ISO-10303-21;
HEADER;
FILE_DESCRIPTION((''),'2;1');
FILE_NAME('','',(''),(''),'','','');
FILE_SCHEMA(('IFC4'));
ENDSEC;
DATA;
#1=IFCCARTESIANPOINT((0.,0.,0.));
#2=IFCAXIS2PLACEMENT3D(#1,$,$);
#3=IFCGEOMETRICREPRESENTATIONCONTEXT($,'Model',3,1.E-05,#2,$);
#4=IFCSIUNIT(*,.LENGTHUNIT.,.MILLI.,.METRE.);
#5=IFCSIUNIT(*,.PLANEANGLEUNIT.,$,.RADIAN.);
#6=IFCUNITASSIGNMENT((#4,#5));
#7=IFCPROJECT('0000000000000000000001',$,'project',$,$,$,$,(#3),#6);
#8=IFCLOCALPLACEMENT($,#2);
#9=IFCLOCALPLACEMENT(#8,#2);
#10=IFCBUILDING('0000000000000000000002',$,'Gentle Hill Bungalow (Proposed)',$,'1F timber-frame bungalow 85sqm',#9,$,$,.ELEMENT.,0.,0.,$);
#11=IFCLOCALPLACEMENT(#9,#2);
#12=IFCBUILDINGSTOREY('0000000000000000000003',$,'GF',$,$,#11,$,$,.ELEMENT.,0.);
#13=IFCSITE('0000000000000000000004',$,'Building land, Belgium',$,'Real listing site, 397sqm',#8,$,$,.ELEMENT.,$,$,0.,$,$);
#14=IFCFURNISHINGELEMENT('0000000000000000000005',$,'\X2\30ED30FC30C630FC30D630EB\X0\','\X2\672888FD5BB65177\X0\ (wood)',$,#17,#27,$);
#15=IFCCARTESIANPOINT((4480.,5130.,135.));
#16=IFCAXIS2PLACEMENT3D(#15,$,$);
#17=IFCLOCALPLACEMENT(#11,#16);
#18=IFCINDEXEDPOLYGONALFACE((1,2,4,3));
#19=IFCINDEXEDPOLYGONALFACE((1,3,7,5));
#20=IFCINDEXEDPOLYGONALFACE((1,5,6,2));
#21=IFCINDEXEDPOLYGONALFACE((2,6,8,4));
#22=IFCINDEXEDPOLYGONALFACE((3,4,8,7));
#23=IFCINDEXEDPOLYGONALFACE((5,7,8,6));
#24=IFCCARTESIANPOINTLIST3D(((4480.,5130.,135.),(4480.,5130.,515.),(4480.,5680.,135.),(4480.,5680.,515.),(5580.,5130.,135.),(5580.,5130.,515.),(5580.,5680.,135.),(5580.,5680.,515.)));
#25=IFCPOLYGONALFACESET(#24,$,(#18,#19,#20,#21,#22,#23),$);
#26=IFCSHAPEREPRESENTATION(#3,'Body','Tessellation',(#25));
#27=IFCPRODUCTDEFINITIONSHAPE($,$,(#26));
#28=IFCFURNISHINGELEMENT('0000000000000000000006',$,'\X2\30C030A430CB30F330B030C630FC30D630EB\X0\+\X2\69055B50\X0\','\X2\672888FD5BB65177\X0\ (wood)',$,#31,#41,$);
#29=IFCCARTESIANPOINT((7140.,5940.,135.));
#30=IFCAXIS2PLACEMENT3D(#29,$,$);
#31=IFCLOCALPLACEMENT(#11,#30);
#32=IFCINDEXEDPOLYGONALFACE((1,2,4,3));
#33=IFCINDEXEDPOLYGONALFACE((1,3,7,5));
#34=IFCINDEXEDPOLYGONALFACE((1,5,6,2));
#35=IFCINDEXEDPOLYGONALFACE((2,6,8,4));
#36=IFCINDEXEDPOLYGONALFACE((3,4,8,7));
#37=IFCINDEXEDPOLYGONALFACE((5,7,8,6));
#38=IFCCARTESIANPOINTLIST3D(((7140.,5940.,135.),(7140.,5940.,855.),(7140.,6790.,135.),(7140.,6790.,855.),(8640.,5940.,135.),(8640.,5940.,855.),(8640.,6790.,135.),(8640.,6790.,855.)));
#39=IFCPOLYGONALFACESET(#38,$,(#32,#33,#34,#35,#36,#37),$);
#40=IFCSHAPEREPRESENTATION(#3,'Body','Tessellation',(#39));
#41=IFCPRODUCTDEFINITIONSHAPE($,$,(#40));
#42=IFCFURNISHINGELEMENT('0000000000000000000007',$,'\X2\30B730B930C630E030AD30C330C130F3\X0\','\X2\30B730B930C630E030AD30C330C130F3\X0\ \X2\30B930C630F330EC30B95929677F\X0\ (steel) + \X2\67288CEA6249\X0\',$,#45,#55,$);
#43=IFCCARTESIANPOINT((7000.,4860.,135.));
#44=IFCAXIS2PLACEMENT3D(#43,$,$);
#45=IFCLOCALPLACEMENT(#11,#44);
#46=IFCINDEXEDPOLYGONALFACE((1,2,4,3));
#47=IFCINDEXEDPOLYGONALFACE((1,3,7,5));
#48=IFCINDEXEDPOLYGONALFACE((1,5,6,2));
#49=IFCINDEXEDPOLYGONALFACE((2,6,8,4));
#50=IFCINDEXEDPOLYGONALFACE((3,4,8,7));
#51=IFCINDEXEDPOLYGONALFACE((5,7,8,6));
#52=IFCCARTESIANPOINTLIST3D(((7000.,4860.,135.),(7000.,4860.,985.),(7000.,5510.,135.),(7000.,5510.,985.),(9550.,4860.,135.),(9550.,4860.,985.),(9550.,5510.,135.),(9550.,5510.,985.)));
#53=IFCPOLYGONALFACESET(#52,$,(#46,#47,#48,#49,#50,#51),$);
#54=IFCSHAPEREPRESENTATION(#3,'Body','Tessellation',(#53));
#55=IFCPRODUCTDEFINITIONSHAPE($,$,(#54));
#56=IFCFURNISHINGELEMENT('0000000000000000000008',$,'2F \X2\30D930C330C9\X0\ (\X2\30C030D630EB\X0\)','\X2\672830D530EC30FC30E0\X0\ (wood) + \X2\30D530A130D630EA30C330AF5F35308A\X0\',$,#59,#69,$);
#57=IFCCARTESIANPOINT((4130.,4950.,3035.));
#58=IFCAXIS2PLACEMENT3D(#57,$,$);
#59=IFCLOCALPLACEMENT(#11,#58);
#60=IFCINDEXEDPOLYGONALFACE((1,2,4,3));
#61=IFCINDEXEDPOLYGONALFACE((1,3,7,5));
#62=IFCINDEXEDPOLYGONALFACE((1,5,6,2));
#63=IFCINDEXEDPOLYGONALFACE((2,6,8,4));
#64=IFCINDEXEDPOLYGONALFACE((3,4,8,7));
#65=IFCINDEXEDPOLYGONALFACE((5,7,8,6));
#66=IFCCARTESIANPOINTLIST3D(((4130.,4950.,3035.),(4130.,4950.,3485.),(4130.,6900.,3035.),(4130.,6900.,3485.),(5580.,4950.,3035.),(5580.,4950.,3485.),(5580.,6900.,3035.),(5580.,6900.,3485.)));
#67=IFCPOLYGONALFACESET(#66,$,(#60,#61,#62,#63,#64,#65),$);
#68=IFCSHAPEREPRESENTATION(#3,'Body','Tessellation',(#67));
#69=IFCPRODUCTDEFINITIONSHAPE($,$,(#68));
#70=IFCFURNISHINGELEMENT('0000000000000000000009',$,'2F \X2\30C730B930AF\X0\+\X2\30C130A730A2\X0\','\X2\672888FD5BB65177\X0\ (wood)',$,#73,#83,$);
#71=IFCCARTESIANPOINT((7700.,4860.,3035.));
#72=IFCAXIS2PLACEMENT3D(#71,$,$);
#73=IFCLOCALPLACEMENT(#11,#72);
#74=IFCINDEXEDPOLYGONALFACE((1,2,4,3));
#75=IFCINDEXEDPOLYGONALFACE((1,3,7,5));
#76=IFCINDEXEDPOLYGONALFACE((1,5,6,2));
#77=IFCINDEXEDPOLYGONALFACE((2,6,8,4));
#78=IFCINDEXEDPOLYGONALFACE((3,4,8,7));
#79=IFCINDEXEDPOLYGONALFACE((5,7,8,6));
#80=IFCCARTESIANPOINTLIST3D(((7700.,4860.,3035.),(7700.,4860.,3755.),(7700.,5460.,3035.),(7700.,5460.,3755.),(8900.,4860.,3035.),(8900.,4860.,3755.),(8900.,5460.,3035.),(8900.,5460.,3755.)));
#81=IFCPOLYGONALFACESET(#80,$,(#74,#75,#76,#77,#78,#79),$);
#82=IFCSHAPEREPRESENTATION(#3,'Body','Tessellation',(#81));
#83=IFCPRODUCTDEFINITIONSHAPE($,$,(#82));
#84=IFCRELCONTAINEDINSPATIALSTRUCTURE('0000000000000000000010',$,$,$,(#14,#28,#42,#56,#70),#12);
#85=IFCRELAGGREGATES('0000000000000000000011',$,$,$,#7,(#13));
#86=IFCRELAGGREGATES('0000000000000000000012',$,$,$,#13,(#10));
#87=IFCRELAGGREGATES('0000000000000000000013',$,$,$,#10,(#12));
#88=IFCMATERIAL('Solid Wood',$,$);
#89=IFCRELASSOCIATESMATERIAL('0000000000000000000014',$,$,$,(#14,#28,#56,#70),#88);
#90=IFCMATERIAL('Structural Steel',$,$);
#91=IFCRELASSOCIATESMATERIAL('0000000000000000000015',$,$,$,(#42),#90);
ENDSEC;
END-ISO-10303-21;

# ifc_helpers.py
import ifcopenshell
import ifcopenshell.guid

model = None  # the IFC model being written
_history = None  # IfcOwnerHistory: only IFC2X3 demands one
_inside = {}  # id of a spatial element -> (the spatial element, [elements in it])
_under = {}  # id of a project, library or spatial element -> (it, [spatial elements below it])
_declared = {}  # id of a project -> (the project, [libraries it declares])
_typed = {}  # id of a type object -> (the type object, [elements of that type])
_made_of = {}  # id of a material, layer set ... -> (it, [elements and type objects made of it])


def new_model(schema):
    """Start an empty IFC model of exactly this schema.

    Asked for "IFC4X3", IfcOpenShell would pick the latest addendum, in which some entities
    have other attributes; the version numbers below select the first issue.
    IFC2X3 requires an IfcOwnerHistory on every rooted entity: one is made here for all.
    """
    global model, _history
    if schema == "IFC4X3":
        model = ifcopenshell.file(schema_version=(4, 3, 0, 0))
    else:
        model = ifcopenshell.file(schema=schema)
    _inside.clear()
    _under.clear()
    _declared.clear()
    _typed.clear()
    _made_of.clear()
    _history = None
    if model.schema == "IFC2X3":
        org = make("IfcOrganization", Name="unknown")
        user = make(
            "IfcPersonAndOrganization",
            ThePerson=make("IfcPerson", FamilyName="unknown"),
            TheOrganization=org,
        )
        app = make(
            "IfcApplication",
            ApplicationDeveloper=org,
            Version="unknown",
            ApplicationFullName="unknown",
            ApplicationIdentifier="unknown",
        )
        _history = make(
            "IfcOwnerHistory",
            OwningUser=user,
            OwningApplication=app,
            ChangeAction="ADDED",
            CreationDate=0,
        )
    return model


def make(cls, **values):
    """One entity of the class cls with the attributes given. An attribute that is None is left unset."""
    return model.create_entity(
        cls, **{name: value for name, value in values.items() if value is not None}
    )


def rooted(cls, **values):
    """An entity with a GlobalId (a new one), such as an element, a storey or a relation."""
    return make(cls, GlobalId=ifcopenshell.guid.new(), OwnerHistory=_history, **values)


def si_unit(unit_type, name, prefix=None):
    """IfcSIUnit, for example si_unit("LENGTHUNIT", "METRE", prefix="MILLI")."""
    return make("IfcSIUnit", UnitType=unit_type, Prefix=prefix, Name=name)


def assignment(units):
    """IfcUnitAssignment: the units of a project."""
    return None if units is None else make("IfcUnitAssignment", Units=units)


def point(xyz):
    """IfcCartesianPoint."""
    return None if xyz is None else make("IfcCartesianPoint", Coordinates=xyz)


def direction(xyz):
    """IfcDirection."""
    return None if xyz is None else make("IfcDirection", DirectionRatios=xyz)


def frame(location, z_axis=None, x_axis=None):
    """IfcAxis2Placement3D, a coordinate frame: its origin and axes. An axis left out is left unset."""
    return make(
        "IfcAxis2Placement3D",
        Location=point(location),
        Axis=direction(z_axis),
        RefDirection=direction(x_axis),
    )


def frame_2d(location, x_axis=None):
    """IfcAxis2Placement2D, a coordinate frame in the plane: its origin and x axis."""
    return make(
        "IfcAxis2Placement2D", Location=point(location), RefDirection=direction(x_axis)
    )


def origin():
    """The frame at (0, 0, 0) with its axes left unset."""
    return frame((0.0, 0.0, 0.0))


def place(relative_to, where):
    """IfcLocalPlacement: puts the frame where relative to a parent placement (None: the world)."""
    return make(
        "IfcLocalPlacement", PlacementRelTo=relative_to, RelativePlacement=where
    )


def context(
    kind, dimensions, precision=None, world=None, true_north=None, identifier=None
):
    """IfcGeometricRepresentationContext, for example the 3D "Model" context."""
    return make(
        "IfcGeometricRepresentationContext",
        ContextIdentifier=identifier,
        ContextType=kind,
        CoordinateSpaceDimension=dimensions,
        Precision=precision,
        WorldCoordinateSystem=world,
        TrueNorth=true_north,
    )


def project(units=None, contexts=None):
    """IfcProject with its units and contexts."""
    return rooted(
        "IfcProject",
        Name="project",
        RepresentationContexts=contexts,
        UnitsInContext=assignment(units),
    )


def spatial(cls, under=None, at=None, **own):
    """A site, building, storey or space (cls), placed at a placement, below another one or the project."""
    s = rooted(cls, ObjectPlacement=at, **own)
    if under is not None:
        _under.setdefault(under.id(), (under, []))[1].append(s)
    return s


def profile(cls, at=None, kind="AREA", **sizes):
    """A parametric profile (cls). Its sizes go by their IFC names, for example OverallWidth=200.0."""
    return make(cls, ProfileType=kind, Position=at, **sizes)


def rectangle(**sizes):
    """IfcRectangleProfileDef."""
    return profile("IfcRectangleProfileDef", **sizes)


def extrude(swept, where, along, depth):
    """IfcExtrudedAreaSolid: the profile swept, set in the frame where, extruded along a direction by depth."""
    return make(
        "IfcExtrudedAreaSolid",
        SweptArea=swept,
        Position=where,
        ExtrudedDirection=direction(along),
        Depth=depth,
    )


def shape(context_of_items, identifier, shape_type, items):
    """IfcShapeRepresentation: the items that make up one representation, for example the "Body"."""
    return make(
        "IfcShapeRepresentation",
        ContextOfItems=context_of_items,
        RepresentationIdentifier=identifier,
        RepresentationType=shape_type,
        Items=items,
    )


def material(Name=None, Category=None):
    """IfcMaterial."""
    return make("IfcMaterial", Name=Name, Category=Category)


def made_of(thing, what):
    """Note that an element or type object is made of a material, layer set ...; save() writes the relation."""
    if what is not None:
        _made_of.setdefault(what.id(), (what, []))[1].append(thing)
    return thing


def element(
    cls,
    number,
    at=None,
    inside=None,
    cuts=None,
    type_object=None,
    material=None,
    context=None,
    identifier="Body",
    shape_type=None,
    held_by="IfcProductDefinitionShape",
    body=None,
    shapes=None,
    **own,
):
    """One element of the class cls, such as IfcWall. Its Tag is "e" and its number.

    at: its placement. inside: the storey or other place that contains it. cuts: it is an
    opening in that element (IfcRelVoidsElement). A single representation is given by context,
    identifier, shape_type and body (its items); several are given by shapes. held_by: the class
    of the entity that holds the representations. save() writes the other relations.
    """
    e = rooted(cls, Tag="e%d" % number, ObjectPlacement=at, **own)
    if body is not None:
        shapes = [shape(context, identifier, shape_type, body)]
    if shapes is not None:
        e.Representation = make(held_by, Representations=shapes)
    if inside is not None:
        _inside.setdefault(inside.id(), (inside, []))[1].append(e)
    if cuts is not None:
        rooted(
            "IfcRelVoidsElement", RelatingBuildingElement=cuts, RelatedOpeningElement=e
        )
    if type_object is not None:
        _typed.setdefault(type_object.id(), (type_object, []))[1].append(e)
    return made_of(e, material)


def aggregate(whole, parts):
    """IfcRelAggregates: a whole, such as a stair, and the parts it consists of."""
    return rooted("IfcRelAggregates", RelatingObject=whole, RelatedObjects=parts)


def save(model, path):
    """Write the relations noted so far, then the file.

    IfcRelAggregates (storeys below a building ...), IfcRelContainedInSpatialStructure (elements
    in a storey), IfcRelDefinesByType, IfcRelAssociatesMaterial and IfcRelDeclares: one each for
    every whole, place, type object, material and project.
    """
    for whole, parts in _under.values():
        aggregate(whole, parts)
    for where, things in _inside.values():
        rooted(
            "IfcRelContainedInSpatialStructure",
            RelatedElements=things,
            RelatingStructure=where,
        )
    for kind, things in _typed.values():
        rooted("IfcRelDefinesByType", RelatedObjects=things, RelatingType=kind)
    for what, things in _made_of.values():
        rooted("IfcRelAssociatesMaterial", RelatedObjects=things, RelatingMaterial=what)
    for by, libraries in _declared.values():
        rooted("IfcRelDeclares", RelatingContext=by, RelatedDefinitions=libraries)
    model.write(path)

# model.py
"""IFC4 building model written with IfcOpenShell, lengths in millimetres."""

from ifc_helpers import new_model, si_unit, frame, frame_2d, origin, place, context, project, spatial, rectangle, extrude, material, element, save


model = new_model("IFC4")

# Units and contexts
model_context = context("Model", 3, precision=1e-05, world=origin())
ifc_project = project(units=[si_unit("LENGTHUNIT", "METRE", prefix="MILLI"), si_unit("PLANEANGLEUNIT", "RADIAN")], contexts=[model_context])

# Site, building, storey
site_placement = place(None, origin())
site = spatial("IfcSite", under=ifc_project, at=site_placement, Name="Building land, Belgium", ObjectType="Real listing site, 397sqm", CompositionType="ELEMENT", RefElevation=0.0)
building_placement = place(site_placement, origin())
building = spatial("IfcBuilding", under=site, at=building_placement, Name="Gentle Hill Bungalow (Proposed)", ObjectType="1F timber-frame bungalow 85sqm", CompositionType="ELEMENT", ElevationOfRefHeight=0.0, ElevationOfTerrain=0.0)
storey_placement = place(building_placement, origin())
storey = spatial("IfcBuildingStorey", under=building, at=storey_placement, Name="GF", CompositionType="ELEMENT", Elevation=0.0)

# Shared definitions
ifc_material_1 = material(Name="Solid Wood")

# Shared definitions
ifc_material_2 = material(Name="Structural Steel")

# Furnishing elements
furnishing_1_placement = place(storey_placement, frame((4480.0, 5130.0, 135.0)))
element("IfcFurnishingElement", 1, at=furnishing_1_placement, inside=storey, material=ifc_material_1, Name="ローテーブル", Description="木製家具 (wood)", context=model_context, shape_type="SweptSolid", body=[
    extrude(rectangle(XDim=1100.0, YDim=550.0, at=frame_2d((550.0, 275.0))), frame((4480.0, 5130.0, 135.0)), (0.0, 0.0, 1.0), 380.0),
])
furnishing_2_placement = place(storey_placement, frame((7140.0, 5940.0, 135.0)))
element("IfcFurnishingElement", 2, at=furnishing_2_placement, inside=storey, material=ifc_material_1, Name="ダイニングテーブル+椅子", Description="木製家具 (wood)", context=model_context, shape_type="SweptSolid", body=[
    extrude(rectangle(XDim=1500.0, YDim=850.0, at=frame_2d((750.0, 425.0))), frame((7140.0, 5940.0, 135.0)), (0.0, 0.0, 1.0), 720.0),
])
furnishing_3_placement = place(storey_placement, frame((7000.0, 4860.0, 135.0)))
element("IfcFurnishingElement", 3, at=furnishing_3_placement, inside=storey, material=ifc_material_2, Name="システムキッチン", Description="システムキッチン ステンレス天板 (steel) + 木質扉", context=model_context, shape_type="SweptSolid", body=[
    extrude(rectangle(XDim=2550.0, YDim=650.0, at=frame_2d((1275.0, 325.0))), frame((7000.0, 4860.0, 135.0)), (0.0, 0.0, 1.0), 850.0),
])
furnishing_4_placement = place(storey_placement, frame((4130.0, 4950.0, 3035.0)))
element("IfcFurnishingElement", 4, at=furnishing_4_placement, inside=storey, material=ifc_material_1, Name="2F ベッド (ダブル)", Description="木フレーム (wood) + ファブリック張り", context=model_context, shape_type="SweptSolid", body=[
    extrude(rectangle(XDim=1450.0, YDim=1950.0, at=frame_2d((725.0, 975.0))), frame((4130.0, 4950.0, 3035.0)), (0.0, 0.0, 1.0), 450.0),
])
furnishing_5_placement = place(storey_placement, frame((7700.0, 4860.0, 3035.0)))
element("IfcFurnishingElement", 5, at=furnishing_5_placement, inside=storey, material=ifc_material_1, Name="2F デスク+チェア", Description="木製家具 (wood)", context=model_context, shape_type="SweptSolid", body=[
    extrude(rectangle(XDim=1200.0, YDim=600.0, at=frame_2d((600.0, 300.0))), frame((7700.0, 4860.0, 3035.0)), (0.0, 0.0, 1.0), 720.0),
])

save(model, "model.ifc")
